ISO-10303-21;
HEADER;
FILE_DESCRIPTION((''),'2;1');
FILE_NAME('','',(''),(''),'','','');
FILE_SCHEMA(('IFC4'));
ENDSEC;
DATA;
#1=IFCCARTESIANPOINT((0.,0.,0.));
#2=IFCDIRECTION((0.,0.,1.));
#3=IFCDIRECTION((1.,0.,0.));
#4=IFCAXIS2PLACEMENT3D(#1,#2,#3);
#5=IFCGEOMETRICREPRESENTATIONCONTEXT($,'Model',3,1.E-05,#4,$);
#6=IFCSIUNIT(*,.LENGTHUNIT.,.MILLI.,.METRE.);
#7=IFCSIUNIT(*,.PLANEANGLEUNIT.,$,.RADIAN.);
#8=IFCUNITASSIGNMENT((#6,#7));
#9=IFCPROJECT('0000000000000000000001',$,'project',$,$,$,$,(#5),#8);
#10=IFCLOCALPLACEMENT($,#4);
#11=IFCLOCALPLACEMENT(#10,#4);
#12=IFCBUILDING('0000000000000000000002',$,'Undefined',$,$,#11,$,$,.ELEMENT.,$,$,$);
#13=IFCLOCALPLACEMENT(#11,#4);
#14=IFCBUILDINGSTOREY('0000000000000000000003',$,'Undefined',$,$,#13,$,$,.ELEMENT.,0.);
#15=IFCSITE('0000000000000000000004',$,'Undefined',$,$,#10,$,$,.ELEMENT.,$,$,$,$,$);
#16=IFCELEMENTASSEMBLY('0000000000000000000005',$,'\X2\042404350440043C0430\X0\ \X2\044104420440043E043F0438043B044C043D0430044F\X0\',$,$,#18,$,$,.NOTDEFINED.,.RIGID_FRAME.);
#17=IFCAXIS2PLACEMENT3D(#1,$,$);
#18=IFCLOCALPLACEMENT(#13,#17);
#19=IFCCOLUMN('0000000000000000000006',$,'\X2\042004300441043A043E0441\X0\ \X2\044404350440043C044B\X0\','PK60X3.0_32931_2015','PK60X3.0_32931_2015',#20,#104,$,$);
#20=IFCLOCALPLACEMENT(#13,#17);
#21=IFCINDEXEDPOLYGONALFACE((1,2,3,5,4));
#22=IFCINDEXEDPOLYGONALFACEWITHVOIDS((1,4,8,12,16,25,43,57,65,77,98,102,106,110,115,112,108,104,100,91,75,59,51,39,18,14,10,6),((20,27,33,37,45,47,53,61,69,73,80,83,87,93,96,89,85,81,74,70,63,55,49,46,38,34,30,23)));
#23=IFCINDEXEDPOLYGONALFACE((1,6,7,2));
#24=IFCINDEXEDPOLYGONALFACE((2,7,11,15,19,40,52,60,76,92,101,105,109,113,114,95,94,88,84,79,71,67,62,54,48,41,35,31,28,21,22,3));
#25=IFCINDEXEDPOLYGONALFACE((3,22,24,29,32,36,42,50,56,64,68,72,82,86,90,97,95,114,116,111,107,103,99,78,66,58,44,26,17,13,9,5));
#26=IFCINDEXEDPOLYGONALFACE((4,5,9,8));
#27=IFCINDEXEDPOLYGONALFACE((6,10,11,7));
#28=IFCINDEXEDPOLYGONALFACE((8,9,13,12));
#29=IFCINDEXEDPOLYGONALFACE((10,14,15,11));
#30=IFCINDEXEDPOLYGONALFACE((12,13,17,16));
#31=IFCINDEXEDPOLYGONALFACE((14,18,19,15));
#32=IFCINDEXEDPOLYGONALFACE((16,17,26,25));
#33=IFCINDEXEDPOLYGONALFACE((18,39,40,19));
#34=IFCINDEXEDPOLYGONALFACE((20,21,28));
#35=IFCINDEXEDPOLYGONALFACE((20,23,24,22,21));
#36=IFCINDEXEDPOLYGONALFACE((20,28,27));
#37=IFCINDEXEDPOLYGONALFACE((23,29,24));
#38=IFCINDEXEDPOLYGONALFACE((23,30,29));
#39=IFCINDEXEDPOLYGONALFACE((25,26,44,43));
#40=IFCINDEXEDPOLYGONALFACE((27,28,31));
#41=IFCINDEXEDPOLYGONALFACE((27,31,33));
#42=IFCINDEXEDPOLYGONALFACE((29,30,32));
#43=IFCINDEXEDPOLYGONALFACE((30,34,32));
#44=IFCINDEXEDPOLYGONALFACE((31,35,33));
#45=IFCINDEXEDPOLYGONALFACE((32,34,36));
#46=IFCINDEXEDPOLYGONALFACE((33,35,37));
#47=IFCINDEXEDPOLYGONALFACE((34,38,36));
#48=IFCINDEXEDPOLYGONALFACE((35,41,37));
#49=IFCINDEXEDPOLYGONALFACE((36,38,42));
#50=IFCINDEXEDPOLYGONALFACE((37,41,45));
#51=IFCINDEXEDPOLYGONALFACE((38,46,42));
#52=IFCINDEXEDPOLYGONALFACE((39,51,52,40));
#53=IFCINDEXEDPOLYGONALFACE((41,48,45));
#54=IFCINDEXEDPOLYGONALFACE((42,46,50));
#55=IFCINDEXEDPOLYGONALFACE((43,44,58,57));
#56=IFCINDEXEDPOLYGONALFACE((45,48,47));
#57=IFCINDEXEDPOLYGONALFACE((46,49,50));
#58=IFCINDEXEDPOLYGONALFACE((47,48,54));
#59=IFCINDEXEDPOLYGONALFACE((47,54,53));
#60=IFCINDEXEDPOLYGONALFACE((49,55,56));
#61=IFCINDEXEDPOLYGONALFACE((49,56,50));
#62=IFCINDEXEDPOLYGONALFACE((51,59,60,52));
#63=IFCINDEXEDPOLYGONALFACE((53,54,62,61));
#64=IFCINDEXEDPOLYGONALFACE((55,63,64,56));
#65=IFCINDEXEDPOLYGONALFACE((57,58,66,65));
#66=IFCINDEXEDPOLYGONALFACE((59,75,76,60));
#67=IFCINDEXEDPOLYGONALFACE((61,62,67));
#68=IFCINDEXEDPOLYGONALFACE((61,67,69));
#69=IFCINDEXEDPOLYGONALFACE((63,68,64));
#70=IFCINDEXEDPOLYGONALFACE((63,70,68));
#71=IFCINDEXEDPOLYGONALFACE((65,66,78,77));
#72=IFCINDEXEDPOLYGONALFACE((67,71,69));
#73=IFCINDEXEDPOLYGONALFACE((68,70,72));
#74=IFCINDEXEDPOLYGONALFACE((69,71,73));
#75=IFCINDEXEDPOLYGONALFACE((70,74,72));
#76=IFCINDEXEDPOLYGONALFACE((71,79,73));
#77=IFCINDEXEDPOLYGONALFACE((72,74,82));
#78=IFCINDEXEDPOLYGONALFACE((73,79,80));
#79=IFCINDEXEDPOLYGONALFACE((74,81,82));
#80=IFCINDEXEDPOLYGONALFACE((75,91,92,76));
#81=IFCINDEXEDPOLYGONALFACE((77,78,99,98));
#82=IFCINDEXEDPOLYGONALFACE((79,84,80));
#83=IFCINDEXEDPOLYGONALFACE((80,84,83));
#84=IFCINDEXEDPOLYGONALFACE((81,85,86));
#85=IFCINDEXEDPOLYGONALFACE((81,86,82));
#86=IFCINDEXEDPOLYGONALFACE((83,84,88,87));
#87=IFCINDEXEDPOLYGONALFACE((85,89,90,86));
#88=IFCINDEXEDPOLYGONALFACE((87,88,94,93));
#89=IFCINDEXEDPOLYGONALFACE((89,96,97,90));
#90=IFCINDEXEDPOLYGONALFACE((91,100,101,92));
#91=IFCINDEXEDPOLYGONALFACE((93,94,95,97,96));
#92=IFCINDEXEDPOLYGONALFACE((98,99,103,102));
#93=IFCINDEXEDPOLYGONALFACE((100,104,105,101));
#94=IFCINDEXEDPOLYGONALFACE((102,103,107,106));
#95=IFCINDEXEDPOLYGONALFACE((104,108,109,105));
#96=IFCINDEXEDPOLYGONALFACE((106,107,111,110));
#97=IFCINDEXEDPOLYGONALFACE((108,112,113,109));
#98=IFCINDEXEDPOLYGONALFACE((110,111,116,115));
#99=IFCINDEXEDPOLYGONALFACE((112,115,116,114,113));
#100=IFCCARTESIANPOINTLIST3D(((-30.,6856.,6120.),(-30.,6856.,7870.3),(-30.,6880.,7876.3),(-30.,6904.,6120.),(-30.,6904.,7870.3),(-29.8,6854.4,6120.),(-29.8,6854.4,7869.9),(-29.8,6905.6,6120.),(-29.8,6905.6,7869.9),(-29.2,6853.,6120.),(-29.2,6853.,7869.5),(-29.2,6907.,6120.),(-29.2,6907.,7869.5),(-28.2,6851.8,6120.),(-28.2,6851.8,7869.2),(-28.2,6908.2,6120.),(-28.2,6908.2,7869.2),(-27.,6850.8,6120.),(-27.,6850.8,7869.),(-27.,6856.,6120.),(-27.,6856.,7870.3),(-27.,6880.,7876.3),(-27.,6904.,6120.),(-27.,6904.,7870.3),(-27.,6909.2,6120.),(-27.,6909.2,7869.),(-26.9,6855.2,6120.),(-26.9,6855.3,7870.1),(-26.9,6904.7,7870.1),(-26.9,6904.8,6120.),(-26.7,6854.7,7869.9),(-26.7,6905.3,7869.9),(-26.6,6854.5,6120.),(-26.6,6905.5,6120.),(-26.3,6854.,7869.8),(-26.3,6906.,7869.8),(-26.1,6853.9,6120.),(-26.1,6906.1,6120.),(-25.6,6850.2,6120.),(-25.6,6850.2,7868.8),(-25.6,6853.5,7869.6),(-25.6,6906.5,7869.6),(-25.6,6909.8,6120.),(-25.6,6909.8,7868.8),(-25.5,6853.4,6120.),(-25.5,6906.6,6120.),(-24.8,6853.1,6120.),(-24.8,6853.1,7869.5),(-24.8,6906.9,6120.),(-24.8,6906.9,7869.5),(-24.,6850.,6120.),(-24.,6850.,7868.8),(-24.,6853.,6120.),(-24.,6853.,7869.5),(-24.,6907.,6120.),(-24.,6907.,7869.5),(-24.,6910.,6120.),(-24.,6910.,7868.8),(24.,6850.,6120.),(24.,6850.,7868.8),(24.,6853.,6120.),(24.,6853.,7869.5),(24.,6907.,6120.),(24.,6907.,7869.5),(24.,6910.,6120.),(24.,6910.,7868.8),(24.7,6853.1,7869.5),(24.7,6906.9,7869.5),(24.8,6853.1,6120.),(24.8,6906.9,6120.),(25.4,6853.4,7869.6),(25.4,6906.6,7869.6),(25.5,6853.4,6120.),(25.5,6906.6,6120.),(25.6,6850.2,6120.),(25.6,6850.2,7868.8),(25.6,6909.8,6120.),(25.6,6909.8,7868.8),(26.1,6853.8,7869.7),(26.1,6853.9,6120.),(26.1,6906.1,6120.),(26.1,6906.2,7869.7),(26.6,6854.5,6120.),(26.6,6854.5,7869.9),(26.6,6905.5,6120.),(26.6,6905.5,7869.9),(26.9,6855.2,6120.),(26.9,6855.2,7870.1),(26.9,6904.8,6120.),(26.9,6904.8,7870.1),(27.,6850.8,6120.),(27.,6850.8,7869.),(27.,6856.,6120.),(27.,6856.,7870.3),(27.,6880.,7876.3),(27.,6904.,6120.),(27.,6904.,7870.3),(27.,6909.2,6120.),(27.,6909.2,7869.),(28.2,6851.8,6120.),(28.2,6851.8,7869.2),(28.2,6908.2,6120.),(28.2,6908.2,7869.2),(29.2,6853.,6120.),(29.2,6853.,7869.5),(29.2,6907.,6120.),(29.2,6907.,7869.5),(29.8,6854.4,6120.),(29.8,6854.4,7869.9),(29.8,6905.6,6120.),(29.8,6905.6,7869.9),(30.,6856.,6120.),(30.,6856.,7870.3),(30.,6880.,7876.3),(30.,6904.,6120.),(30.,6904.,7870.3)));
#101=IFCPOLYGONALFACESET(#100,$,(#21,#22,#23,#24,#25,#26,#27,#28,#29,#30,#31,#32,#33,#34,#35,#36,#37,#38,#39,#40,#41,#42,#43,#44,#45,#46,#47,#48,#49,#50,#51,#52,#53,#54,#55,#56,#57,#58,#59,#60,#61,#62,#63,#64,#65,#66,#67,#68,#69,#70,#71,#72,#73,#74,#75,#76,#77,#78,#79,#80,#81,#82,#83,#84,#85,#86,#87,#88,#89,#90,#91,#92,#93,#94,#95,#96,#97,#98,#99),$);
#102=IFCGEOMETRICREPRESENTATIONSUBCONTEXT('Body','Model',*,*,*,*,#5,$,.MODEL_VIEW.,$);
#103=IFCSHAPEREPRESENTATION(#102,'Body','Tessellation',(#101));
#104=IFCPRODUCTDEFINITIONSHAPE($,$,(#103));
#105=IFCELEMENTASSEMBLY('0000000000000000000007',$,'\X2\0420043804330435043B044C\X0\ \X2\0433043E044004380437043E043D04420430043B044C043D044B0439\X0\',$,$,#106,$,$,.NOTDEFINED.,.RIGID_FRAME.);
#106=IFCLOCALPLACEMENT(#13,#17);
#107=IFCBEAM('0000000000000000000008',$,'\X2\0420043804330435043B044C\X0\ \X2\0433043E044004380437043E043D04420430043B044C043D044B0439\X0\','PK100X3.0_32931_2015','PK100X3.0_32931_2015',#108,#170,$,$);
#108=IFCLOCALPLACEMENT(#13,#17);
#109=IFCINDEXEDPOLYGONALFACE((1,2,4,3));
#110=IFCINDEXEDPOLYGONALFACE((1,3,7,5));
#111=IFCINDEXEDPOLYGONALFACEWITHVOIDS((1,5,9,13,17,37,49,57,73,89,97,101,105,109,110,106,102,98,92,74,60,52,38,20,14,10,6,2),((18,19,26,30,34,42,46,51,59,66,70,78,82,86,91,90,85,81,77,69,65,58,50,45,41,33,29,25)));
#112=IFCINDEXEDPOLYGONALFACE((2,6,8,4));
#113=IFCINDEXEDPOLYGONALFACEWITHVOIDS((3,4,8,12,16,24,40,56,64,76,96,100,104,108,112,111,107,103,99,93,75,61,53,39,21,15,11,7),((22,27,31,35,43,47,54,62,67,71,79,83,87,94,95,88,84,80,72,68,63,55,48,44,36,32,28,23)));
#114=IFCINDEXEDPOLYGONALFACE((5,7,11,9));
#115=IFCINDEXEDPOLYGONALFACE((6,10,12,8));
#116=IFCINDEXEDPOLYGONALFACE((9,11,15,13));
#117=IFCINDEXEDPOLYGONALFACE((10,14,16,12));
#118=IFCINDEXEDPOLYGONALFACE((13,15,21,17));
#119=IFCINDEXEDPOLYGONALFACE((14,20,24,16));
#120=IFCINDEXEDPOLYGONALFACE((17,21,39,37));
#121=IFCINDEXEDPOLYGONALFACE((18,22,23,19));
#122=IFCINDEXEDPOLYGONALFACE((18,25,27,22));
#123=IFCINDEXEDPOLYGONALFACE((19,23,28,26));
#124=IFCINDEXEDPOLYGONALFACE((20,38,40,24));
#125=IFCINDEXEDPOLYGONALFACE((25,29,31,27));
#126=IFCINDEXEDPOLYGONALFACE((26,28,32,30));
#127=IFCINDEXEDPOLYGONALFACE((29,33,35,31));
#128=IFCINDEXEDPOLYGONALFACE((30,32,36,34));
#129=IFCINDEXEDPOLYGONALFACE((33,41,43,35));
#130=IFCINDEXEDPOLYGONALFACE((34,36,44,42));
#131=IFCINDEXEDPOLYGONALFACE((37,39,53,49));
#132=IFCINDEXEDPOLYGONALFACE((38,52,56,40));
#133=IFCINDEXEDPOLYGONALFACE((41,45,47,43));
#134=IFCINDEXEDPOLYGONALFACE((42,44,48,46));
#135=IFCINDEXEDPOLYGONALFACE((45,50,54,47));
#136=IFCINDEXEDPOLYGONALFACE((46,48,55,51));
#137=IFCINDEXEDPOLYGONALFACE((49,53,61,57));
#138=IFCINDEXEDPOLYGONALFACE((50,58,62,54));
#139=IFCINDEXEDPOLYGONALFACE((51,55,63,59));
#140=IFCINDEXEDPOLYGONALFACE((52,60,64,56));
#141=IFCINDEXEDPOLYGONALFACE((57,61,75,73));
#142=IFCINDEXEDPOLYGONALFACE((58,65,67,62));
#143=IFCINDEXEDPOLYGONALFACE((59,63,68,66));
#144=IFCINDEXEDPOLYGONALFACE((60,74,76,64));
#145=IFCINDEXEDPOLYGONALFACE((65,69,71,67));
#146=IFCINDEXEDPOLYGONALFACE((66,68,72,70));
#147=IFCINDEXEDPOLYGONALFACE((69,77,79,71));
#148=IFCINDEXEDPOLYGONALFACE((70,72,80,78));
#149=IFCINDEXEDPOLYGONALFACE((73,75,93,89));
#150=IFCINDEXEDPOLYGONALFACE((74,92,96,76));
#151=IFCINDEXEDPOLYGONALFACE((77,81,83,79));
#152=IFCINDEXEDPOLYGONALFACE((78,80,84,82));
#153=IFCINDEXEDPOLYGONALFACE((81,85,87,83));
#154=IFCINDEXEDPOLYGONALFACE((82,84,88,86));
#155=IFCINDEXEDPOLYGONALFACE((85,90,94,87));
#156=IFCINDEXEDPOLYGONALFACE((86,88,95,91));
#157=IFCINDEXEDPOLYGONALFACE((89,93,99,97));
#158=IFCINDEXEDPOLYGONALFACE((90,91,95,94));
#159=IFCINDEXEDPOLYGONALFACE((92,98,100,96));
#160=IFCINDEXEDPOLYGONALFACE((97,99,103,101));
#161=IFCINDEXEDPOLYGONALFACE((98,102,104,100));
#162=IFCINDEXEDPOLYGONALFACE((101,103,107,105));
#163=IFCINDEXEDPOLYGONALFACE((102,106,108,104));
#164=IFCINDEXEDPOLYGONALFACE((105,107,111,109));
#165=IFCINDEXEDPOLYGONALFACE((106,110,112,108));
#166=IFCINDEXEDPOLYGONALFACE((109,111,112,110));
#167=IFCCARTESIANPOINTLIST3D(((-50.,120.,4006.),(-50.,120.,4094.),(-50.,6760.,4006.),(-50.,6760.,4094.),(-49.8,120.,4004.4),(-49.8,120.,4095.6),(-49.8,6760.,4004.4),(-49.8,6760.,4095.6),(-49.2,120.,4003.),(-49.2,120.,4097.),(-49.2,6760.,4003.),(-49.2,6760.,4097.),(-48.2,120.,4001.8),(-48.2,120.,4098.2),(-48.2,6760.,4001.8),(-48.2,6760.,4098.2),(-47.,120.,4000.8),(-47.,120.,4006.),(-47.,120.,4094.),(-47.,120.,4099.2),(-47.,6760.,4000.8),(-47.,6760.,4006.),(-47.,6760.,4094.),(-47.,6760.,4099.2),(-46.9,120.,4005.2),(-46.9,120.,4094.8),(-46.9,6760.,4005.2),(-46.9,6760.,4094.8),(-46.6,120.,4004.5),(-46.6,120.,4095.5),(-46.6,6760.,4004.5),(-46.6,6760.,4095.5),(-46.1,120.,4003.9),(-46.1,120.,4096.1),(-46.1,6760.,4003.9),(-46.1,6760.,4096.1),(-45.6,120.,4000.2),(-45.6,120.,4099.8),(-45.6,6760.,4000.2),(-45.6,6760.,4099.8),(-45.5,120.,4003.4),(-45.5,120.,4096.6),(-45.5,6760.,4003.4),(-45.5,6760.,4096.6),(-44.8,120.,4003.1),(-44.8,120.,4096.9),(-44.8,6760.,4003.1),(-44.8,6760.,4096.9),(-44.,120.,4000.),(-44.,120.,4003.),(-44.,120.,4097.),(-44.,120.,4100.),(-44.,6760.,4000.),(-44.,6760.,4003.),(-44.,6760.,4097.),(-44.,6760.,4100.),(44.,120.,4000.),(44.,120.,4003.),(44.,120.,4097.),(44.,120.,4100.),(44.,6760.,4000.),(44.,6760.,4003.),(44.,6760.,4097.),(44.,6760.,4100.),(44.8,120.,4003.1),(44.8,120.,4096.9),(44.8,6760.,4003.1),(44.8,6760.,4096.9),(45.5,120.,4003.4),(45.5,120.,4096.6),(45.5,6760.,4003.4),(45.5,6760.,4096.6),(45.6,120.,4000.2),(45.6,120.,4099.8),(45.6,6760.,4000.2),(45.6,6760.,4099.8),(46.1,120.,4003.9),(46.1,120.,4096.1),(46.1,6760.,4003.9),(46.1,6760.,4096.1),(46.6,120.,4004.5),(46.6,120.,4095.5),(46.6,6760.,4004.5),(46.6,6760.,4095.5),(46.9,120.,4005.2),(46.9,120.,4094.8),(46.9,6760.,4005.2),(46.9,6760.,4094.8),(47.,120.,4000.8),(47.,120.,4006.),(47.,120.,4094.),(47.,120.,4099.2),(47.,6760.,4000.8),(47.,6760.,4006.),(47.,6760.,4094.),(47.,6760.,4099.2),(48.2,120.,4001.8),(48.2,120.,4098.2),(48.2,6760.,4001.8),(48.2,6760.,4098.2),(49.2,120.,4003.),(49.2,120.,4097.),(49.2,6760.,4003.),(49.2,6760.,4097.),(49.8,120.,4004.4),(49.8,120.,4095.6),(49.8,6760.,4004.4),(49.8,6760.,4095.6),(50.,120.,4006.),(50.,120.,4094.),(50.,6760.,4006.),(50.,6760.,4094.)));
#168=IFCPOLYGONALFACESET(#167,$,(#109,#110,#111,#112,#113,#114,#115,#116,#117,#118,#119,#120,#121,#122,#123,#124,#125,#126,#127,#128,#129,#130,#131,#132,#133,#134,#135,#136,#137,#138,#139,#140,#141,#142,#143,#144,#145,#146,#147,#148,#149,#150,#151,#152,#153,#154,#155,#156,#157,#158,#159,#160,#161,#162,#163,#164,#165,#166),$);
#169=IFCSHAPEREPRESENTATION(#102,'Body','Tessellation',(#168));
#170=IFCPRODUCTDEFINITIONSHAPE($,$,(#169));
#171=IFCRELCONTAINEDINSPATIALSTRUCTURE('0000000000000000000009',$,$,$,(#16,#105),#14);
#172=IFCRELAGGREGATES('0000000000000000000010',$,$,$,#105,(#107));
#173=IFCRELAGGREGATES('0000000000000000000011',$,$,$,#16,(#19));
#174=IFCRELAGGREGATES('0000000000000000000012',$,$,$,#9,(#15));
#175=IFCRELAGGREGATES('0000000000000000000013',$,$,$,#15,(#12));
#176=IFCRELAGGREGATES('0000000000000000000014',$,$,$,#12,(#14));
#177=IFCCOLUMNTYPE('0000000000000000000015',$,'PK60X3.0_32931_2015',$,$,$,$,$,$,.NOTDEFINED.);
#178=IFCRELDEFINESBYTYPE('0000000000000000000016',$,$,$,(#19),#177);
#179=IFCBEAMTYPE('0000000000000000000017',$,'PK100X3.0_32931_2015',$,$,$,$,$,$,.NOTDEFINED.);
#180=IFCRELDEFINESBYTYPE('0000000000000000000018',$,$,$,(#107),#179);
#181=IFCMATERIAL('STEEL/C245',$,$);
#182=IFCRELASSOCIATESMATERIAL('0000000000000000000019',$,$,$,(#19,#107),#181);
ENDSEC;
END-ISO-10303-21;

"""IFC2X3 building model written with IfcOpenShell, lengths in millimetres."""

from ifc_helpers import new_model, si_unit, frame, origin_with_axes, origin_2d_with_axis, place, context, subcontext, project, spatial, hollow_rectangle, extrude, clip, halfspace, material, type_object, element, aggregate, save


model = new_model("IFC2X3")

# Units and contexts
model_context = context("Model", 3, precision=1e-05, world=origin_with_axes())
body_context = subcontext(model_context, "Body", "Model", "MODEL_VIEW")
ifc_project = project(units=[si_unit("LENGTHUNIT", "METRE", prefix="MILLI"), si_unit("PLANEANGLEUNIT", "RADIAN")], contexts=[model_context])

# Site, building, storey
site_placement = place(None, origin_with_axes())
site = spatial("IfcSite", under=ifc_project, at=site_placement, Name="Undefined", CompositionType="ELEMENT")
building_placement = place(site_placement, origin_with_axes())
building = spatial("IfcBuilding", under=site, at=building_placement, Name="Undefined", CompositionType="ELEMENT")
storey_placement = place(building_placement, origin_with_axes())
storey = spatial("IfcBuildingStorey", under=building, at=storey_placement, Name="Undefined", CompositionType="ELEMENT", Elevation=0.0)

# Shared definitions
ifc_material = material(Name="STEEL/C245")

# Element assembly, column
assembly_1_placement = place(storey_placement, origin_with_axes())
assembly_1 = element("IfcElementAssembly", 1, at=assembly_1_placement, inside=storey, Name="Ферма стропильная", AssemblyPlace="NOTDEFINED", PredefinedType="RIGID_FRAME")
column_type_1 = type_object("IfcColumnType", Name="PK60X3.0_32931_2015", PredefinedType="NOTDEFINED")
column_1_placement = place(assembly_1_placement, frame((0.0, 6880.0, 6120.0), z_axis=(0.0, 0.0, 1.0), x_axis=(-1.0, 0.0, 0.0)))
column_1 = element("IfcColumn", 2, at=column_1_placement, type_object=column_type_1, material=ifc_material, Name="Раскос фермы", Description="PK60X3.0_32931_2015", ObjectType="PK60X3.0_32931_2015", context=body_context, shape_type="Clipping", body=[
    clip(clip(extrude(hollow_rectangle(XDim=60.0, YDim=60.0, WallThickness=3.0, InnerFilletRadius=3.0, OuterFilletRadius=6.0, at=origin_2d_with_axis()), frame((0.0, 0.0, 1756.3), z_axis=(0.0, 0.0, -1.0), x_axis=(0.0, 1.0, 0.0)), (0.0, 0.0, 1.0), 1756.3), halfspace(frame((-30.0, 30.0, 1763.8), z_axis=(0.0, -0.243188, 0.969979), x_axis=(1.0, 0.0, 0.0)), False)), halfspace(frame((0.0, 4455.7, 639.2), z_axis=(0.0, -0.243188, -0.969979), x_axis=(-1.0, 0.0, 0.0)), True)),
])

# Element assembly, beam
assembly_2_placement = place(storey_placement, origin_with_axes())
assembly_2 = element("IfcElementAssembly", 3, at=assembly_2_placement, inside=storey, Name="Ригель горизонтальный", AssemblyPlace="NOTDEFINED", PredefinedType="RIGID_FRAME")
beam_type_1 = type_object("IfcBeamType", Name="PK100X3.0_32931_2015", PredefinedType="NOTDEFINED")
beam_1_placement = place(assembly_2_placement, frame((0.0, 120.0, 4050.0), z_axis=(0.0, 0.0, 1.0), x_axis=(0.0, 1.0, 0.0)))
beam_1 = element("IfcBeam", 4, at=beam_1_placement, type_object=beam_type_1, material=ifc_material, Name="Ригель горизонтальный", Description="PK100X3.0_32931_2015", ObjectType="PK100X3.0_32931_2015", context=body_context, shape_type="SweptSolid", body=[
    extrude(hollow_rectangle(XDim=100.0, YDim=100.0, WallThickness=3.0, InnerFilletRadius=3.0, OuterFilletRadius=6.0, at=origin_2d_with_axis()), frame((6640.0, 0.0, 0.0), z_axis=(-1.0, 0.0, 0.0), x_axis=(0.0, -1.0, 0.0)), (0.0, 0.0, 1.0), 6640.0),
])
aggregate(assembly_2, [beam_1])

aggregate(assembly_1, [column_1])

save(model, "model.ifc")
